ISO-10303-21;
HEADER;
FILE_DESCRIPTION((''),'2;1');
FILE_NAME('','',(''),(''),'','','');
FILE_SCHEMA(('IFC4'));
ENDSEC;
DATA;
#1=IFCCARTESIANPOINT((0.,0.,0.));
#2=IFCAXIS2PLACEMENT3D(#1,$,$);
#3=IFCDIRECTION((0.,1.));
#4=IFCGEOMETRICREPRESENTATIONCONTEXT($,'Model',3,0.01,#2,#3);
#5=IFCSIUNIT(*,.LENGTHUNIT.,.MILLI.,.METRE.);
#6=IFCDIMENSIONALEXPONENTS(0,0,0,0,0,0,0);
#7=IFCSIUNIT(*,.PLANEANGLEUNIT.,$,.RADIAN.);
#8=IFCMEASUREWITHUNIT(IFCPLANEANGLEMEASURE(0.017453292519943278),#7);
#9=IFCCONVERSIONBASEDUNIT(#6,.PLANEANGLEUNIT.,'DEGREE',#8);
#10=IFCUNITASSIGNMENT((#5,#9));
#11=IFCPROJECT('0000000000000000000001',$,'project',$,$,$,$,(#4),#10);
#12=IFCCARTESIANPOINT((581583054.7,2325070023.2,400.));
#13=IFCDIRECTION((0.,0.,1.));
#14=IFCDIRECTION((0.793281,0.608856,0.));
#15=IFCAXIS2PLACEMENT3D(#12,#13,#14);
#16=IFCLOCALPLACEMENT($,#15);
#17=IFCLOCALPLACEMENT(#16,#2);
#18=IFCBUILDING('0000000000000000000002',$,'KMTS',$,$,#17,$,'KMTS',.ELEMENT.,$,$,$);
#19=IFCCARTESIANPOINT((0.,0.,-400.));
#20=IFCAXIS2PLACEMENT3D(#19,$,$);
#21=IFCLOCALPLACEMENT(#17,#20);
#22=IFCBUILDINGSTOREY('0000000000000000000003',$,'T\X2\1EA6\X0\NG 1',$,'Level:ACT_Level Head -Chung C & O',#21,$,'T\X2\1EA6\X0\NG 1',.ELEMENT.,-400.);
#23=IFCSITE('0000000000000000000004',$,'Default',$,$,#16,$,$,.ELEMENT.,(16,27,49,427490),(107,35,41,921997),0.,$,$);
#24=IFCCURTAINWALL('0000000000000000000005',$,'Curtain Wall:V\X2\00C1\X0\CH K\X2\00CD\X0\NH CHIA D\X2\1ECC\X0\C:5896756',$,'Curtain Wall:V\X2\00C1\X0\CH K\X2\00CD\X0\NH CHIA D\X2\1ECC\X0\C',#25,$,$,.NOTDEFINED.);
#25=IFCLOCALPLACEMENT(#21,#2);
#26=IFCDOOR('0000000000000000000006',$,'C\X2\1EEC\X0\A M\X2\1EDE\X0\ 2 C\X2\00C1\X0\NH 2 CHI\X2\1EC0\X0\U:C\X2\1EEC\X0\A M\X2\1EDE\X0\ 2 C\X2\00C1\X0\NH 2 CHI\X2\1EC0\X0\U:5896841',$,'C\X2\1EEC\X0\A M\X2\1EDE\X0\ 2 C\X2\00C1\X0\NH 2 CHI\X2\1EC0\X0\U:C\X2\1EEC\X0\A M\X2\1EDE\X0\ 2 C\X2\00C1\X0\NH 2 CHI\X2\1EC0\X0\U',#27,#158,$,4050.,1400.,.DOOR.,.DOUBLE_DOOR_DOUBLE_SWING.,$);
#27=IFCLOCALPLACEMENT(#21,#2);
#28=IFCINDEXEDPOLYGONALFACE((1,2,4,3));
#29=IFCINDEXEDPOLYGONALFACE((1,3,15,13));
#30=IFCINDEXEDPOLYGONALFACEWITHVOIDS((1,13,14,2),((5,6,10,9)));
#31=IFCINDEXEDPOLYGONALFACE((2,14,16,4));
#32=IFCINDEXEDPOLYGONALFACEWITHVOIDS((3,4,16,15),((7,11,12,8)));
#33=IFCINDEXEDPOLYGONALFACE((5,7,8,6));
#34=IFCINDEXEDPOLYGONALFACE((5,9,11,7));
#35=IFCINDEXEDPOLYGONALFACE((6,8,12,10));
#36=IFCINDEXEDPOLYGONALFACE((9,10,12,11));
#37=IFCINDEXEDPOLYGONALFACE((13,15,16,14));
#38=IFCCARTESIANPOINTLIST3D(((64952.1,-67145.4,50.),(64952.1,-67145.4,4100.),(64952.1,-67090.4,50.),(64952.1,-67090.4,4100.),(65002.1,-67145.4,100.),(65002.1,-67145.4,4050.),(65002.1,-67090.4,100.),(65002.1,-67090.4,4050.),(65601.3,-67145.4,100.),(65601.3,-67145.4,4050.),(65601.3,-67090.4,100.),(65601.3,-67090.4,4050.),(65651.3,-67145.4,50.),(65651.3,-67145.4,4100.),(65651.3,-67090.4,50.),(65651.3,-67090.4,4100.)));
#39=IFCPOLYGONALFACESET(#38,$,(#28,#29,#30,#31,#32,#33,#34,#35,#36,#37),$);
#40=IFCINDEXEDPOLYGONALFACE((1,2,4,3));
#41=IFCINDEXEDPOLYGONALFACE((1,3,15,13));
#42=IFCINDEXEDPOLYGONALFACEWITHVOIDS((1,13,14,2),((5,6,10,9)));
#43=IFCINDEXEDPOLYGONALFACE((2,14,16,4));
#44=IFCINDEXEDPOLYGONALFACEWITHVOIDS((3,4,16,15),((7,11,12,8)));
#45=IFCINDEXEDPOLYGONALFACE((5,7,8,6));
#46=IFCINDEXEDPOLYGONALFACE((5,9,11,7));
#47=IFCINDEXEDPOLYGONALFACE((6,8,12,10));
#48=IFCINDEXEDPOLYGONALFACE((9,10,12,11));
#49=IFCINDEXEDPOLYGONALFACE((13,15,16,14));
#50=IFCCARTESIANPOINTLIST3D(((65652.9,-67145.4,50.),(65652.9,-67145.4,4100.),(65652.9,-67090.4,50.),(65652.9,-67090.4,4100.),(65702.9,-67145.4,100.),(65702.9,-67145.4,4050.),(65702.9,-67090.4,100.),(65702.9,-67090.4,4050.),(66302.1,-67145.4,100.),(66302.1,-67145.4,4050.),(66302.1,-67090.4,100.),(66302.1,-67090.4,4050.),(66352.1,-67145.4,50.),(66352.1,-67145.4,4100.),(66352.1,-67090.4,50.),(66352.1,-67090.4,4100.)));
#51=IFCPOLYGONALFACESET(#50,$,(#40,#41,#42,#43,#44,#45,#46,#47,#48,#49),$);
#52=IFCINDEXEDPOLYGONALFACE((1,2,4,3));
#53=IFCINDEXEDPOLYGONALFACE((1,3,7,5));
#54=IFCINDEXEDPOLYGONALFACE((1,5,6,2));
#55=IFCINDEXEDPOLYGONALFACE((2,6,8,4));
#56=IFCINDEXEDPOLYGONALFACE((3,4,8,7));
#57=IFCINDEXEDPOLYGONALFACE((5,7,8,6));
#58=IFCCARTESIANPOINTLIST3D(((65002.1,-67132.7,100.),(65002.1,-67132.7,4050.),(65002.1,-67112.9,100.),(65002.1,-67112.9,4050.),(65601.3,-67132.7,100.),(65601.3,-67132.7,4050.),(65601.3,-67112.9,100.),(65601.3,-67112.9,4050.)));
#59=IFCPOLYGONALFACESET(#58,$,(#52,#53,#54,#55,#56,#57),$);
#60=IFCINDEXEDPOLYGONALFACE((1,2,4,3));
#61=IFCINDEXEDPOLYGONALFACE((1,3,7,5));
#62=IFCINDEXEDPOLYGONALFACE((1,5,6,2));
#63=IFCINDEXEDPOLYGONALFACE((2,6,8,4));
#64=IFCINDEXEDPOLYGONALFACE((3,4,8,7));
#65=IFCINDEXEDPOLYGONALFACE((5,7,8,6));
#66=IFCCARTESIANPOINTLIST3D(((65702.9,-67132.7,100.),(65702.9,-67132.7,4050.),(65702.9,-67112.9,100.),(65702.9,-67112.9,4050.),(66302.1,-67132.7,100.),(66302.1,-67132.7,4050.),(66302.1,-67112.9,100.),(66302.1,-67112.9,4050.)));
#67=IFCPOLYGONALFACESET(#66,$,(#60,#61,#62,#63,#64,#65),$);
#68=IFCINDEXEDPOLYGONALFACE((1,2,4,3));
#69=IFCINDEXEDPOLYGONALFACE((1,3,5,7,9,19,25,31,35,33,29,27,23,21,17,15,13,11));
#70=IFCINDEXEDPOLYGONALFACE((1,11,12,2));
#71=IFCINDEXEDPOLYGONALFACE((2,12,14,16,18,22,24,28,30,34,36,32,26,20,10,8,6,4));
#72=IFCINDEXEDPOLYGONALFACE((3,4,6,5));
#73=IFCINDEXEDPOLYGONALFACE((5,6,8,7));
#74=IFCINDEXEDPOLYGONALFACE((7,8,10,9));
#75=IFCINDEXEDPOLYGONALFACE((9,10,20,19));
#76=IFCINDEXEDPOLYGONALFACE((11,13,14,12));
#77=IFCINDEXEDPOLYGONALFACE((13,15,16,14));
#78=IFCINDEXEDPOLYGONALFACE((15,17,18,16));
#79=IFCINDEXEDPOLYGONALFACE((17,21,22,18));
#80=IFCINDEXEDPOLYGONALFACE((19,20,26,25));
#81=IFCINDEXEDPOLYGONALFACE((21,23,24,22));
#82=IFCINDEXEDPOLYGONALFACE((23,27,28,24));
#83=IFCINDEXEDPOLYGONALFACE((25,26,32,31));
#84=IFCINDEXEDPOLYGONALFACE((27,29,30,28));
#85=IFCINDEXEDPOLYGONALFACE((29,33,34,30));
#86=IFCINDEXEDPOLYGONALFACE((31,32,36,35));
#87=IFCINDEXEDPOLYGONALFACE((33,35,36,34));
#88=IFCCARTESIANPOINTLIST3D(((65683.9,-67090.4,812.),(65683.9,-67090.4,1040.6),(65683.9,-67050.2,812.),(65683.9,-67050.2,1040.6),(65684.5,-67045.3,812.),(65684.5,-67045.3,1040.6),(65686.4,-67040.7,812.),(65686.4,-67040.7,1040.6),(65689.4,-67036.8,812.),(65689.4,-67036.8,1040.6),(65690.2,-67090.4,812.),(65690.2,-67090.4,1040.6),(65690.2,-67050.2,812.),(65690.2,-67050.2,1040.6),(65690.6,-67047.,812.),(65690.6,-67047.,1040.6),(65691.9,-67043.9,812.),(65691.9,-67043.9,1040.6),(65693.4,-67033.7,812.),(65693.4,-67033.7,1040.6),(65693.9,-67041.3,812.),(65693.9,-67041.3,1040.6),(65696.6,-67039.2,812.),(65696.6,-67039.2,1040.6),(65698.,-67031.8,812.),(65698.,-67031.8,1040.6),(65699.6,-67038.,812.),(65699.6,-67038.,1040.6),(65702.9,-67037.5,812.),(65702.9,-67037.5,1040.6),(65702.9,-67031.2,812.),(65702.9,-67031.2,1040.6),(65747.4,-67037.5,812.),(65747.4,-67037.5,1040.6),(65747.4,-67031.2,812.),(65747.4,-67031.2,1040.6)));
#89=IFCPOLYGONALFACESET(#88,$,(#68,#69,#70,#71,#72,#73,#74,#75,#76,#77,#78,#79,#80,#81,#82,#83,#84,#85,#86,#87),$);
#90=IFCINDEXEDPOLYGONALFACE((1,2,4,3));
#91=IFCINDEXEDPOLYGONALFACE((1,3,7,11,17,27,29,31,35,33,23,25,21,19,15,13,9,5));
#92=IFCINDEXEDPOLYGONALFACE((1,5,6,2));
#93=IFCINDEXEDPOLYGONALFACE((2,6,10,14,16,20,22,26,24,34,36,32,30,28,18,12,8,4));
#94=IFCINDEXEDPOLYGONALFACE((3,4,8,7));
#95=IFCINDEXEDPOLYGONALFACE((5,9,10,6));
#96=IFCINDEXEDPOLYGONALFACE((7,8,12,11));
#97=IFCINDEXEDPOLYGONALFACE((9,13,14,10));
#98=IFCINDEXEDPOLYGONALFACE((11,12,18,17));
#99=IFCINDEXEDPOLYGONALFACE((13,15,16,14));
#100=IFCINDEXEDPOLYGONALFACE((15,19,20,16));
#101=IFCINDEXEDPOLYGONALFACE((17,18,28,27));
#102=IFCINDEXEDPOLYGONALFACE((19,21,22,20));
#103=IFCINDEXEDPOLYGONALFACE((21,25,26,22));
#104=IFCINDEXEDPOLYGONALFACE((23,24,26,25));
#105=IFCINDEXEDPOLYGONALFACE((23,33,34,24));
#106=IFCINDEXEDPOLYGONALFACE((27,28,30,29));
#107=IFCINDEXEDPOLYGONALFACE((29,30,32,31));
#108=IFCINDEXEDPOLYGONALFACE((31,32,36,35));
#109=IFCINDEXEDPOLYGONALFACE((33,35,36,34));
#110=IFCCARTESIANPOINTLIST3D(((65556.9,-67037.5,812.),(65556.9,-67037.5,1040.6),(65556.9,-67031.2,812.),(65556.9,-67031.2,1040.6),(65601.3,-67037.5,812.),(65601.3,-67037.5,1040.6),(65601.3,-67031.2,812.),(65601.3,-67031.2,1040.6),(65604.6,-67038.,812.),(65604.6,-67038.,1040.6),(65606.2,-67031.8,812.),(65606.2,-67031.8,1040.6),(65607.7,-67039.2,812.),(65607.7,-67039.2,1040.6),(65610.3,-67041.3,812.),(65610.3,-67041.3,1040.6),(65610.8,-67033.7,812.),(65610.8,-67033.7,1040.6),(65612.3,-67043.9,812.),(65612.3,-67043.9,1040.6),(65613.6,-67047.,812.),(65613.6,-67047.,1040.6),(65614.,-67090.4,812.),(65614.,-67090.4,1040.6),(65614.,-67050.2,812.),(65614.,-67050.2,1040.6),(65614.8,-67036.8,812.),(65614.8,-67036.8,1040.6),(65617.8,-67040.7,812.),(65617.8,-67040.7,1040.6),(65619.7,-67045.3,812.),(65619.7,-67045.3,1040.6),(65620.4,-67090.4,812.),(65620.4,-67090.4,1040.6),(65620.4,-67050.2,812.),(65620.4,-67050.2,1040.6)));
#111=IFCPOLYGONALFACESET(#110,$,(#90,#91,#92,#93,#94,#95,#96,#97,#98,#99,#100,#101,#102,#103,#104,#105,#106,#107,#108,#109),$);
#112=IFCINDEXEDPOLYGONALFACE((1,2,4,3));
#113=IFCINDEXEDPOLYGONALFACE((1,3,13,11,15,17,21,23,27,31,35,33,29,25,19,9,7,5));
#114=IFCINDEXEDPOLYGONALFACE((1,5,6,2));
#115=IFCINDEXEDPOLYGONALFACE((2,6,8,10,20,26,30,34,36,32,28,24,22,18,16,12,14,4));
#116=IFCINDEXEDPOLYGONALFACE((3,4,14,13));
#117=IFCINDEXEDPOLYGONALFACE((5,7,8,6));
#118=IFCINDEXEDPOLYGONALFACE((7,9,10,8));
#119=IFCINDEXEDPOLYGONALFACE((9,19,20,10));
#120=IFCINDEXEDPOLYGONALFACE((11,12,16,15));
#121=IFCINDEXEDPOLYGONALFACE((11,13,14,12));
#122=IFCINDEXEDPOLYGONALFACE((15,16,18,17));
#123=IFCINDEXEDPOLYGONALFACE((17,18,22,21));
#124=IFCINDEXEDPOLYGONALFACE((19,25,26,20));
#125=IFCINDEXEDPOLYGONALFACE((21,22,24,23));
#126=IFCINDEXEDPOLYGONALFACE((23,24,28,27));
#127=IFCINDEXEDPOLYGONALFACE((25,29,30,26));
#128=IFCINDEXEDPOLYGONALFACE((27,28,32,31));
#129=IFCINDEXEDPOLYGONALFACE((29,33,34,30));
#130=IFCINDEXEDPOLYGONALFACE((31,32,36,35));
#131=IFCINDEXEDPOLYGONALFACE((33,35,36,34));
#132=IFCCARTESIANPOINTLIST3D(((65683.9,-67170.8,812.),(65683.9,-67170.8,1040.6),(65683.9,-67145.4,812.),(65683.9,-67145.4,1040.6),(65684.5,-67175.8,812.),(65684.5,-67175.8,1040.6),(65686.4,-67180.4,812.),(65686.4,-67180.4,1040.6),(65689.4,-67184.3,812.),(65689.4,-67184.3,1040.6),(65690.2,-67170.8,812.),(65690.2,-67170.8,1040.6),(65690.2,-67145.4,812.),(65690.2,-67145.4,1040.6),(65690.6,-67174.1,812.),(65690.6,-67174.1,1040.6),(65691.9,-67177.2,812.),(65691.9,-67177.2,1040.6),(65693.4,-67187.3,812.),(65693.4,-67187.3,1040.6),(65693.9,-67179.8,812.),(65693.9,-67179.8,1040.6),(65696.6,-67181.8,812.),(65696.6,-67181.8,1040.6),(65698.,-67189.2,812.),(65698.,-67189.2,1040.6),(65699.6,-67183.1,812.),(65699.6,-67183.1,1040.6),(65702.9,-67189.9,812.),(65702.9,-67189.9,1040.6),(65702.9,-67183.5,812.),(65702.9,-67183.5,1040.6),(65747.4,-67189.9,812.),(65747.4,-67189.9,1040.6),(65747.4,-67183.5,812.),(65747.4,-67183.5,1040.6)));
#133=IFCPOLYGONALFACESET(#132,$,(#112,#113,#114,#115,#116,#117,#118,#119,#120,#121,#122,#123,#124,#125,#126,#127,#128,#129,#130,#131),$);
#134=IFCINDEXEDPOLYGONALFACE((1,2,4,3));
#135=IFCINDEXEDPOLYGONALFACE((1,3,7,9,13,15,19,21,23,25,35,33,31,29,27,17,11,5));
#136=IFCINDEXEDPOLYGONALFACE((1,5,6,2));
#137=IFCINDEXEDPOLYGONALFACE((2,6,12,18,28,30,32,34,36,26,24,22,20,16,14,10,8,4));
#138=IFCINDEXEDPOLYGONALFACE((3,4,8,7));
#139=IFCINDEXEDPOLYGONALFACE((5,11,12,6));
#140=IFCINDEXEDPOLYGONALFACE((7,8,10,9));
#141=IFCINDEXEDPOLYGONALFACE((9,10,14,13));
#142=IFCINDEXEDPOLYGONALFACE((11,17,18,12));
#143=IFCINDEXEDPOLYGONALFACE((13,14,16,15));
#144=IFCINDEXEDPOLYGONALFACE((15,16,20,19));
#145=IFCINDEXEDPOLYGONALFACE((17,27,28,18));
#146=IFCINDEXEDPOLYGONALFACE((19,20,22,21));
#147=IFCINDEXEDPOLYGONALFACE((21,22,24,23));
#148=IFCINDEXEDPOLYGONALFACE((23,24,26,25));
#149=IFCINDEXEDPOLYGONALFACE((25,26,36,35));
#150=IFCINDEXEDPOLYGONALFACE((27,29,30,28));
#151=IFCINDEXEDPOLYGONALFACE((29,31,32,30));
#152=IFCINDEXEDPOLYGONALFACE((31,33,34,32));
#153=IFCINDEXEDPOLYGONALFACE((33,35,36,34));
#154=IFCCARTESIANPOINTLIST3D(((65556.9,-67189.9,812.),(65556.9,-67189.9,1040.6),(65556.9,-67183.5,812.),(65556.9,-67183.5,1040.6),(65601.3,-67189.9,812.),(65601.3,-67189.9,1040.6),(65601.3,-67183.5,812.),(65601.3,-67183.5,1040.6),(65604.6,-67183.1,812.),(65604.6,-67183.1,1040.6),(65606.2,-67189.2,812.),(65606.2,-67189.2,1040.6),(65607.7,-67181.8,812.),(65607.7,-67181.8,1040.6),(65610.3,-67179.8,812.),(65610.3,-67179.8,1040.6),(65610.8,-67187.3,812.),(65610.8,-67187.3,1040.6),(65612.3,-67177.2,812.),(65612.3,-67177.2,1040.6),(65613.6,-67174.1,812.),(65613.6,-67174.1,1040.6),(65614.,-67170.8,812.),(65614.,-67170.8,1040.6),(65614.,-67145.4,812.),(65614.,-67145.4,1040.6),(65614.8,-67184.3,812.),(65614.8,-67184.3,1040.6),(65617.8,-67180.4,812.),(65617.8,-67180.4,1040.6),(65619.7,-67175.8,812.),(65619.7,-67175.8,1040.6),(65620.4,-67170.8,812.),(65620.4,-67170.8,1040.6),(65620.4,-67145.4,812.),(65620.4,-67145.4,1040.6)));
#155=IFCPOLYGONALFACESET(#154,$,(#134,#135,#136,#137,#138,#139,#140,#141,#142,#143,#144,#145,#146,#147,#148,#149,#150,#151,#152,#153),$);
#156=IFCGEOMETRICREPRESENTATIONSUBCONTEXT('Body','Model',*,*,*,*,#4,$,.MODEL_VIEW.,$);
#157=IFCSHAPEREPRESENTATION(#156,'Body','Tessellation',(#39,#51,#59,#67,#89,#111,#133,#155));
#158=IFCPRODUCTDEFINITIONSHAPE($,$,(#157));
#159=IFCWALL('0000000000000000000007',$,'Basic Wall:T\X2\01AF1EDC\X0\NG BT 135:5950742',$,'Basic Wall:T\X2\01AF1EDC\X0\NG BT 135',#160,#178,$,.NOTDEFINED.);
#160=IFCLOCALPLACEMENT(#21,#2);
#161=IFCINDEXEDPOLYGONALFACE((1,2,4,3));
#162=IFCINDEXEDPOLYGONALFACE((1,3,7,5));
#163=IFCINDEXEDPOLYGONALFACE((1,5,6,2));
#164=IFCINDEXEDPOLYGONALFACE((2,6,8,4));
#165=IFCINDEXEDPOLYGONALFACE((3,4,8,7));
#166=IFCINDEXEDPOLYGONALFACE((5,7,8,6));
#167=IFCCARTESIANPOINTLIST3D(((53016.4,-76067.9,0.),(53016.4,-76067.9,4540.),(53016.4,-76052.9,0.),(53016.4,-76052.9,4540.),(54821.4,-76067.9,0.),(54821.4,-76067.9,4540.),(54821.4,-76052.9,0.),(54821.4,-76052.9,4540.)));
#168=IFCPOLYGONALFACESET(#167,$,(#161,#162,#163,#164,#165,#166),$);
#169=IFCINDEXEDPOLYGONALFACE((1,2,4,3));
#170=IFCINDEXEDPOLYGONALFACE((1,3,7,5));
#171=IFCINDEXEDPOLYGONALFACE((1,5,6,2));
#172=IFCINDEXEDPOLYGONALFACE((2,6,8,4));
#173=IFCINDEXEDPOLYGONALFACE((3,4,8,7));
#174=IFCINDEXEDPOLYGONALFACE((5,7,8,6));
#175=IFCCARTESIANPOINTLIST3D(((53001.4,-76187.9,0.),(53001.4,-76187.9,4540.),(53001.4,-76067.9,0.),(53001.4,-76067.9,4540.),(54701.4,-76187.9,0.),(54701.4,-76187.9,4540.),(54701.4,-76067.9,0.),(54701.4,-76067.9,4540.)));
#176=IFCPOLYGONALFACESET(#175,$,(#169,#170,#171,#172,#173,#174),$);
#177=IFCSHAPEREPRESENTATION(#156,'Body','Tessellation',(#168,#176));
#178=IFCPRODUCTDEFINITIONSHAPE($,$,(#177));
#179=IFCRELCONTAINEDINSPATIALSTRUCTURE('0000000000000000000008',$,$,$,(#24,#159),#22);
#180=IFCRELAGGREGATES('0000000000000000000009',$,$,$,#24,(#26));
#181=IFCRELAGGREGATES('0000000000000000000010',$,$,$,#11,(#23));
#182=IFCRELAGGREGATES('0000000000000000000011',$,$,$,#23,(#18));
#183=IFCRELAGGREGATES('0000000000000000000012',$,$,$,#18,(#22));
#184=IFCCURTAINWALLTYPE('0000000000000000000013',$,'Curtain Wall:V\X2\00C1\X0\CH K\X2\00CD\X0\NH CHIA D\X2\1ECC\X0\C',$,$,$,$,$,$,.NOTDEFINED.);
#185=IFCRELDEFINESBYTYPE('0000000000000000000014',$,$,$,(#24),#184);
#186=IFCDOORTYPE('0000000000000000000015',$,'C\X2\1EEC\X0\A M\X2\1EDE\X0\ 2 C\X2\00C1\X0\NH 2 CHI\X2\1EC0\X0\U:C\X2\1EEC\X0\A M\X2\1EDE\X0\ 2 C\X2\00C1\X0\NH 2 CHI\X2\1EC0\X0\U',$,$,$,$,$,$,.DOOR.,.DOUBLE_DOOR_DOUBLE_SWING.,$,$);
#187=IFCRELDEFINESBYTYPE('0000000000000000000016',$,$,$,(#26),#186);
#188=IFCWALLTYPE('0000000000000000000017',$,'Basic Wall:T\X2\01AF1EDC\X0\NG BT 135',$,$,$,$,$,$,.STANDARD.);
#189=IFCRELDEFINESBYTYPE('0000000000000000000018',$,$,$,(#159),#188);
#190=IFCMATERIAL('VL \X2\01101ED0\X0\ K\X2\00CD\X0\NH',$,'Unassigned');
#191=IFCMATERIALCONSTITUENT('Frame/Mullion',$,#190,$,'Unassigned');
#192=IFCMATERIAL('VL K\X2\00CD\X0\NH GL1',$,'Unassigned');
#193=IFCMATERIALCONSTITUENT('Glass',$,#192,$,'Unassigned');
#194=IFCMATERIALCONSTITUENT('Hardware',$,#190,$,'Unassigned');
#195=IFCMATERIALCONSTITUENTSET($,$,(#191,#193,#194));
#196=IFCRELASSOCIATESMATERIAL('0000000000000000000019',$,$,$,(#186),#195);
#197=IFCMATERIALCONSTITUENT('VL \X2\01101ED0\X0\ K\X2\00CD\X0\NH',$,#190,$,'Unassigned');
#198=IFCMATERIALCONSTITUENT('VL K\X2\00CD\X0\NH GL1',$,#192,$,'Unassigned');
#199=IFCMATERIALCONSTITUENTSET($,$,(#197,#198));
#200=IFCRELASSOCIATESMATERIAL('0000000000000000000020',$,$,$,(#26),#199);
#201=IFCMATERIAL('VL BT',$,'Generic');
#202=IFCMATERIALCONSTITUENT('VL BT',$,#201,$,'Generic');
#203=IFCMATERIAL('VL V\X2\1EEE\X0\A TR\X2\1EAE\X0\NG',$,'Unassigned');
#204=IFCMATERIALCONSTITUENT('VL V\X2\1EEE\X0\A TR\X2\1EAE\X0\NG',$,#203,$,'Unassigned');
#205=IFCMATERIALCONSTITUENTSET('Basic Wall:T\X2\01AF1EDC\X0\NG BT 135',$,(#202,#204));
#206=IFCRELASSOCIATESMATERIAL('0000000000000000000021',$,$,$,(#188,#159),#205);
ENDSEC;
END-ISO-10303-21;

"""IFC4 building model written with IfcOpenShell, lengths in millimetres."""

from ifc_helpers import new_model, entity, si_unit, converted_unit, direction, frame, origin, place, context, subcontext, project, spatial, line, arc, indexed_curve, outline, extrude, source, transform, mapped, material, constituent, constituent_set, type_object, type_shapes, element, aggregate, save


model = new_model("IFC4")

# Units and contexts
model_context = context("Model", 3, precision=0.01, world=origin(), true_north=direction((0.0, 1.0)))
body_context = subcontext(model_context, "Body", "Model", "MODEL_VIEW")
ifc_project = project(units=[si_unit("LENGTHUNIT", "METRE", prefix="MILLI"), converted_unit("PLANEANGLEUNIT", "DEGREE", entity("IfcPlaneAngleMeasure", 0.017453292519943278), si_unit("PLANEANGLEUNIT", "RADIAN"), dimensions=[0, 0, 0, 0, 0, 0, 0])], contexts=[model_context])

# Site, building, storey
site_placement = place(None, frame((581583054.7, 2325070023.2, 400.0), z_axis=(0.0, 0.0, 1.0), x_axis=(0.793281, 0.608856, 0.0)))
site = spatial("IfcSite", under=ifc_project, at=site_placement, Name="Default", CompositionType="ELEMENT", RefLatitude=(16, 27, 49, 427490), RefLongitude=(107, 35, 41, 921997), RefElevation=0.0)
building_placement = place(site_placement, origin())
building = spatial("IfcBuilding", under=site, at=building_placement, Name="KMTS", LongName="KMTS", CompositionType="ELEMENT")
storey_placement = place(building_placement, frame((0.0, 0.0, -400.0)))
storey = spatial("IfcBuildingStorey", under=building, at=storey_placement, Name="TẦNG 1", ObjectType="Level:ACT_Level Head -Chung C & O", LongName="TẦNG 1", CompositionType="ELEMENT", Elevation=-400.0)

# Curtain wall
curtain_wall_type = type_object("IfcCurtainWallType", Name="Curtain Wall:VÁCH KÍNH CHIA DỌC", PredefinedType="NOTDEFINED")
curtain_wall_1_placement = place(storey_placement, frame((0.0, 0.0, 400.0)))
curtain_wall_1 = element("IfcCurtainWall", 1, at=curtain_wall_1_placement, inside=storey, type_object=curtain_wall_type, Name="Curtain Wall:VÁCH KÍNH CHIA DỌC:5896756", ObjectType="Curtain Wall:VÁCH KÍNH CHIA DỌC", PredefinedType="NOTDEFINED")
ifc_material_1 = material(Name="VL ĐỐ KÍNH", Category="Unassigned")

# Shared definitions
ifc_material_2 = material(Name="VL VỮA TRẮNG", Category="Unassigned")
ifc_material_3 = material(Name="VL BT", Category="Generic")

# Door
ifc_material_4 = material(Name="VL KÍNH GL1", Category="Unassigned")
ifc_constituent_1 = constituent(ifc_material_1, Name="VL ĐỐ KÍNH", Category="Unassigned")
ifc_constituent_2 = constituent(ifc_material_4, Name="VL KÍNH GL1", Category="Unassigned")
ifc_constituent_set_1 = constituent_set(constituents=[ifc_constituent_1, ifc_constituent_2])
ifc_constituent_3 = constituent(ifc_material_1, Name="Frame/Mullion", Category="Unassigned")
ifc_constituent_4 = constituent(ifc_material_4, Name="Glass", Category="Unassigned")
ifc_constituent_5 = constituent(ifc_material_1, Name="Hardware", Category="Unassigned")
ifc_constituent_set_2 = constituent_set(constituents=[ifc_constituent_3, ifc_constituent_4, ifc_constituent_5])
door_type_1 = type_object("IfcDoorType", Name="CỬA MỞ 2 CÁNH 2 CHIỀU:CỬA MỞ 2 CÁNH 2 CHIỀU", OperationType="DOUBLE_DOOR_DOUBLE_SWING", PredefinedType="DOOR", material=ifc_constituent_set_2)
shared_shape_1 = source(origin(), body_context, "Body", "SweptSolid", [
    extrude(outline(indexed_curve([(-2025.0, -349.6), (2025.0, -349.6), (2025.0, 349.6), (-2025.0, 349.6), (-2025.0, -349.6)], self_intersect=False), holes=[indexed_curve([(-1975.0, 299.6), (1975.0, 299.6), (1975.0, -299.6), (-1975.0, -299.6), (-1975.0, 299.6)], self_intersect=False)]), frame((350.4, 27.5, 2025.0), z_axis=(0.0, -1.0, 0.0), x_axis=(0.0, 0.0, -1.0)), (0.0, 0.0, 1.0), 55.0),
    extrude(outline(indexed_curve([(-349.6, -2025.0), (349.6, -2025.0), (349.6, 2025.0), (-349.6, 2025.0), (-349.6, -2025.0)], self_intersect=False), holes=[indexed_curve([(-299.6, -1975.0), (-299.6, 1975.0), (299.6, 1975.0), (299.6, -1975.0), (-299.6, -1975.0)], self_intersect=False)]), frame((-350.4, 27.5, 2025.0), z_axis=(0.0, -1.0, 0.0), x_axis=(-1.0, 0.0, 0.0)), (0.0, 0.0, 1.0), 55.0),
    extrude(outline(indexed_curve([(-299.6, -9.9), (299.6, -9.9), (299.6, 9.9), (-299.6, 9.9), (-299.6, -9.9)], self_intersect=False)), frame((350.4, 4.9, 50.0)), (0.0, 0.0, 1.0), 3950.0),
    extrude(outline(indexed_curve([(-299.6, -9.9), (299.6, -9.9), (299.6, 9.9), (-299.6, 9.9), (-299.6, -9.9)], self_intersect=False)), frame((-350.4, 4.9, 50.0)), (0.0, 0.0, 1.0), 3950.0),
    extrude(outline(indexed_curve([(-2.1, -22.2), (38.1, -22.2), (38.1, -15.9), (-2.1, -15.9), (-11.1, -12.2), (-14.8, -3.2), (-14.8, 41.3), (-21.2, 41.3), (-21.2, -3.2), (-15.6, -16.6)], segments=[line(1, 2, 3, 4), arc(4, 5, 6), line(6, 7, 8, 9), arc(9, 10, 1)], self_intersect=False)), frame((-54.0, -65.6, 762.0), z_axis=(0.0, 0.0, 1.0), x_axis=(0.0, 1.0, 0.0)), (0.0, 0.0, 1.0), 228.6),
    extrude(outline(indexed_curve([(22.2, 2.1), (16.6, 15.6), (3.2, 21.2), (-41.3, 21.2), (-41.3, 14.8), (3.2, 14.8), (12.2, 11.1), (15.9, 2.1), (15.9, -38.1), (22.2, -38.1)], segments=[arc(1, 2, 3), line(3, 4, 5, 6), arc(6, 7, 8), line(8, 9, 10, 1)], self_intersect=False)), frame((54.0, -65.6, 762.0), z_axis=(0.0, 0.0, 1.0), x_axis=(-1.0, 0.0, 0.0)), (0.0, 0.0, 1.0), 228.6),
    extrude(outline(indexed_curve([(-22.2, 1.6), (-16.6, -11.9), (-3.2, -17.5), (41.3, -17.5), (41.3, -11.1), (-3.2, -11.1), (-12.2, -7.4), (-15.9, 1.6), (-15.9, 27.0), (-22.2, 27.0)], segments=[arc(1, 2, 3), line(3, 4, 5, 6), arc(6, 7, 8), line(8, 9, 10, 1)], self_intersect=False)), frame((-54.0, 54.5, 762.0), z_axis=(0.0, 0.0, 1.0), x_axis=(-1.0, 0.0, 0.0)), (0.0, 0.0, 1.0), 228.6),
    extrude(outline(indexed_curve([(1.6, -22.2), (27.0, -22.2), (27.0, -15.9), (1.6, -15.9), (-7.4, -12.2), (-11.1, -3.2), (-11.1, 41.3), (-17.5, 41.3), (-17.5, -3.2), (-11.9, -16.6)], segments=[line(1, 2, 3, 4), arc(4, 5, 6), line(6, 7, 8, 9), arc(9, 10, 1)], self_intersect=False)), frame((54.0, 54.5, 762.0), z_axis=(0.0, 0.0, 1.0), x_axis=(0.0, -1.0, 0.0)), (0.0, 0.0, 1.0), 228.6),
])
type_shapes(door_type_1, [shared_shape_1])
door_1_placement = place(curtain_wall_1_placement, frame((65652.1, -67117.9, -350.0), z_axis=(0.0, 0.0, 1.0), x_axis=(-1.0, 0.0, 0.0)))
door_1 = element("IfcDoor", 2, at=door_1_placement, type_object=door_type_1, material=ifc_constituent_set_1, Name="CỬA MỞ 2 CÁNH 2 CHIỀU:CỬA MỞ 2 CÁNH 2 CHIỀU:5896841", ObjectType="CỬA MỞ 2 CÁNH 2 CHIỀU:CỬA MỞ 2 CÁNH 2 CHIỀU", OperationType="DOUBLE_DOOR_DOUBLE_SWING", OverallHeight=4050.0, OverallWidth=1400.0, PredefinedType="DOOR", context=body_context, shape_type="MappedRepresentation", body=[
    mapped(shared_shape_1, transform((0.0, 0.0, 0.0), scale=1.0)),
])
aggregate(curtain_wall_1, [door_1])

# Wall
ifc_constituent_6 = constituent(ifc_material_3, Name="VL BT", Category="Generic")
ifc_constituent_7 = constituent(ifc_material_2, Name="VL VỮA TRẮNG", Category="Unassigned")
ifc_constituent_set_3 = constituent_set(constituents=[ifc_constituent_6, ifc_constituent_7], Name="Basic Wall:TƯỜNG BT 135")
wall_type_1 = type_object("IfcWallType", Name="Basic Wall:TƯỜNG BT 135", PredefinedType="STANDARD", material=ifc_constituent_set_3)
wall_1_placement = place(storey_placement, frame((54701.4, -76120.4, 0.0), z_axis=(0.0, 0.0, 1.0), x_axis=(-1.0, 0.0, 0.0)))
element("IfcWall", 3, at=wall_1_placement, inside=storey, type_object=wall_type_1, material=ifc_constituent_set_3, Name="Basic Wall:TƯỜNG BT 135:5950742", ObjectType="Basic Wall:TƯỜNG BT 135", PredefinedType="NOTDEFINED", context=body_context, shape_type="SweptSolid", body=[
    extrude(outline(indexed_curve([(-7.5, -902.5), (7.5, -902.5), (7.5, 902.5), (-7.5, 902.5), (-7.5, -902.5)], self_intersect=False)), frame((782.5, -60.0, 0.0), z_axis=(0.0, 0.0, 1.0), x_axis=(0.0, 1.0, 0.0)), (0.0, 0.0, 1.0), 4540.0),
    extrude(outline(indexed_curve([(-60.0, -850.0), (60.0, -850.0), (60.0, 850.0), (-60.0, 850.0), (-60.0, -850.0)], self_intersect=False)), frame((850.0, 7.5, 0.0), z_axis=(0.0, 0.0, 1.0), x_axis=(0.0, -1.0, 0.0)), (0.0, 0.0, 1.0), 4540.0),
])

save(model, "model.ifc")
